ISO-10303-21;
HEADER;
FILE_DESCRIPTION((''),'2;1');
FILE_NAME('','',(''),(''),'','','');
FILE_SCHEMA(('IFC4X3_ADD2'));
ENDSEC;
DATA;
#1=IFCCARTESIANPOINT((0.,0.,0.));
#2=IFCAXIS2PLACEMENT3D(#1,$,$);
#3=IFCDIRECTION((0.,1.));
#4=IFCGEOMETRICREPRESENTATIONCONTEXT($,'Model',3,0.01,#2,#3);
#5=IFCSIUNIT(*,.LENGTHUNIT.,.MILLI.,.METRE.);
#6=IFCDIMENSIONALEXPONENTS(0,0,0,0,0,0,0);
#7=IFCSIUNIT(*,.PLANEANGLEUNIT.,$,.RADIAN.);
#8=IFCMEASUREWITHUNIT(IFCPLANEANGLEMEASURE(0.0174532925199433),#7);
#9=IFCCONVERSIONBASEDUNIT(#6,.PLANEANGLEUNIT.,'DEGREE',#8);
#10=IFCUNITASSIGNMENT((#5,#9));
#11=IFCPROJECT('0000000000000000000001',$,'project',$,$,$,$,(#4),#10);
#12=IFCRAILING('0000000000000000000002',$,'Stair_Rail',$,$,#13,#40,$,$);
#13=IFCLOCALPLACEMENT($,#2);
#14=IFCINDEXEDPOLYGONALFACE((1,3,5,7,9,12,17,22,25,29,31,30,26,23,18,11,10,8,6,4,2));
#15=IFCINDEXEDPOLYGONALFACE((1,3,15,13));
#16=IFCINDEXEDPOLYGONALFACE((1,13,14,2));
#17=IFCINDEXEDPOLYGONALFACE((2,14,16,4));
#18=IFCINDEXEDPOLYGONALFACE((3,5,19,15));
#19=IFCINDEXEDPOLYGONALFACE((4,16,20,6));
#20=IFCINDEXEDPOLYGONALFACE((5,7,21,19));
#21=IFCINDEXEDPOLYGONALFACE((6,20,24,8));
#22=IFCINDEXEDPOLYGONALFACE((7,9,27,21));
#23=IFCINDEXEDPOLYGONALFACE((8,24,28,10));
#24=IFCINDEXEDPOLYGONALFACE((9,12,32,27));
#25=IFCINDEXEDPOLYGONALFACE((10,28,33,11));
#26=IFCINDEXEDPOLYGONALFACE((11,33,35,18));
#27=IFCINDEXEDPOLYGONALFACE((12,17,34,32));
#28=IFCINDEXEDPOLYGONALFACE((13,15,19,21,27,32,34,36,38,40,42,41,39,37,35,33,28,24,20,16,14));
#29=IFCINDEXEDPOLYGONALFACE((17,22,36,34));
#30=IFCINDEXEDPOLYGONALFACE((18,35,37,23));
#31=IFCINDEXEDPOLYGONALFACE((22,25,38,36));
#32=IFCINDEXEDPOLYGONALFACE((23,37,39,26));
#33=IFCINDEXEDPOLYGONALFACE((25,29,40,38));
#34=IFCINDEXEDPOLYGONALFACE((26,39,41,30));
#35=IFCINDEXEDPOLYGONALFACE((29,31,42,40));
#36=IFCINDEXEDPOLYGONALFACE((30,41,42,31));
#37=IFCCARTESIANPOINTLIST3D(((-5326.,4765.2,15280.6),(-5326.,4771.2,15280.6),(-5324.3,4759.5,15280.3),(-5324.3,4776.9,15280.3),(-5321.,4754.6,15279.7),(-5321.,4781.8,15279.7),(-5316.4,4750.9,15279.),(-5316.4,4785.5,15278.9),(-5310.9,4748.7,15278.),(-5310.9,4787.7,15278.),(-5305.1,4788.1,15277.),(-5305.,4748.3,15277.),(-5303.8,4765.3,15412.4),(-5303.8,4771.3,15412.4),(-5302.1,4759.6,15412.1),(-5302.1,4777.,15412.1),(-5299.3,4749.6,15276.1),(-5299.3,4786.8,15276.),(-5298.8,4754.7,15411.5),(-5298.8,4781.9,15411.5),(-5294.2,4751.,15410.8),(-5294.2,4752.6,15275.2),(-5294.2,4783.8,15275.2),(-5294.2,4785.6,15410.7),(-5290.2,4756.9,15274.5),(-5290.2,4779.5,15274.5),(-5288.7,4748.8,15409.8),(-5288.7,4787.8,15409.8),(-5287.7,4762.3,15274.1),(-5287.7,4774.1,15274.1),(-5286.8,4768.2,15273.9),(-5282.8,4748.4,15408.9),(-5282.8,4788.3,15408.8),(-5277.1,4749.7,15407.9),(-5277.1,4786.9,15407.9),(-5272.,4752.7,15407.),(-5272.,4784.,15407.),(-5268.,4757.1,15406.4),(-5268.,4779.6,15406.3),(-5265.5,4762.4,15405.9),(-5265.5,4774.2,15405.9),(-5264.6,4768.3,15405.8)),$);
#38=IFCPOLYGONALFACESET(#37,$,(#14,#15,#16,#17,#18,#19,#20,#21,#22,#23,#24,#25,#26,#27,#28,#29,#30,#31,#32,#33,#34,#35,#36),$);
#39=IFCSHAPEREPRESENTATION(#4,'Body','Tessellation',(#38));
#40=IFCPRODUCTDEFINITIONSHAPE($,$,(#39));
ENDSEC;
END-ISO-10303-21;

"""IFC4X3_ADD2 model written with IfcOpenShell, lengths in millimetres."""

from ifc_helpers import new_model, entity, si_unit, converted_unit, direction, origin, context, project, element, save


model = new_model("IFC4X3_ADD2")

# Units and contexts
model_context = context("Model", 3, precision=0.01, world=origin(), true_north=direction((0.0, 1.0)))
ifc_project = project(units=[si_unit("LENGTHUNIT", "METRE", prefix="MILLI"), converted_unit("PLANEANGLEUNIT", "DEGREE", entity("IfcPlaneAngleMeasure", 0.0174532925199433), si_unit("PLANEANGLEUNIT", "RADIAN"), dimensions=[0, 0, 0, 0, 0, 0, 0])], contexts=[model_context])

# Railing
element("IfcRailing", 1, Name="Stair_Rail", context=model_context, shape_type="SweptSolid", body=[
    entity("IfcSweptDiskSolid", entity("IfcPolyline", [entity("IfcCartesianPoint", [-5306.5, 4768.2, 15277.3]), entity("IfcCartesianPoint", [-5284.3, 4768.3, 15409.1])]), 20.0),
])

save(model, "model.ifc")
